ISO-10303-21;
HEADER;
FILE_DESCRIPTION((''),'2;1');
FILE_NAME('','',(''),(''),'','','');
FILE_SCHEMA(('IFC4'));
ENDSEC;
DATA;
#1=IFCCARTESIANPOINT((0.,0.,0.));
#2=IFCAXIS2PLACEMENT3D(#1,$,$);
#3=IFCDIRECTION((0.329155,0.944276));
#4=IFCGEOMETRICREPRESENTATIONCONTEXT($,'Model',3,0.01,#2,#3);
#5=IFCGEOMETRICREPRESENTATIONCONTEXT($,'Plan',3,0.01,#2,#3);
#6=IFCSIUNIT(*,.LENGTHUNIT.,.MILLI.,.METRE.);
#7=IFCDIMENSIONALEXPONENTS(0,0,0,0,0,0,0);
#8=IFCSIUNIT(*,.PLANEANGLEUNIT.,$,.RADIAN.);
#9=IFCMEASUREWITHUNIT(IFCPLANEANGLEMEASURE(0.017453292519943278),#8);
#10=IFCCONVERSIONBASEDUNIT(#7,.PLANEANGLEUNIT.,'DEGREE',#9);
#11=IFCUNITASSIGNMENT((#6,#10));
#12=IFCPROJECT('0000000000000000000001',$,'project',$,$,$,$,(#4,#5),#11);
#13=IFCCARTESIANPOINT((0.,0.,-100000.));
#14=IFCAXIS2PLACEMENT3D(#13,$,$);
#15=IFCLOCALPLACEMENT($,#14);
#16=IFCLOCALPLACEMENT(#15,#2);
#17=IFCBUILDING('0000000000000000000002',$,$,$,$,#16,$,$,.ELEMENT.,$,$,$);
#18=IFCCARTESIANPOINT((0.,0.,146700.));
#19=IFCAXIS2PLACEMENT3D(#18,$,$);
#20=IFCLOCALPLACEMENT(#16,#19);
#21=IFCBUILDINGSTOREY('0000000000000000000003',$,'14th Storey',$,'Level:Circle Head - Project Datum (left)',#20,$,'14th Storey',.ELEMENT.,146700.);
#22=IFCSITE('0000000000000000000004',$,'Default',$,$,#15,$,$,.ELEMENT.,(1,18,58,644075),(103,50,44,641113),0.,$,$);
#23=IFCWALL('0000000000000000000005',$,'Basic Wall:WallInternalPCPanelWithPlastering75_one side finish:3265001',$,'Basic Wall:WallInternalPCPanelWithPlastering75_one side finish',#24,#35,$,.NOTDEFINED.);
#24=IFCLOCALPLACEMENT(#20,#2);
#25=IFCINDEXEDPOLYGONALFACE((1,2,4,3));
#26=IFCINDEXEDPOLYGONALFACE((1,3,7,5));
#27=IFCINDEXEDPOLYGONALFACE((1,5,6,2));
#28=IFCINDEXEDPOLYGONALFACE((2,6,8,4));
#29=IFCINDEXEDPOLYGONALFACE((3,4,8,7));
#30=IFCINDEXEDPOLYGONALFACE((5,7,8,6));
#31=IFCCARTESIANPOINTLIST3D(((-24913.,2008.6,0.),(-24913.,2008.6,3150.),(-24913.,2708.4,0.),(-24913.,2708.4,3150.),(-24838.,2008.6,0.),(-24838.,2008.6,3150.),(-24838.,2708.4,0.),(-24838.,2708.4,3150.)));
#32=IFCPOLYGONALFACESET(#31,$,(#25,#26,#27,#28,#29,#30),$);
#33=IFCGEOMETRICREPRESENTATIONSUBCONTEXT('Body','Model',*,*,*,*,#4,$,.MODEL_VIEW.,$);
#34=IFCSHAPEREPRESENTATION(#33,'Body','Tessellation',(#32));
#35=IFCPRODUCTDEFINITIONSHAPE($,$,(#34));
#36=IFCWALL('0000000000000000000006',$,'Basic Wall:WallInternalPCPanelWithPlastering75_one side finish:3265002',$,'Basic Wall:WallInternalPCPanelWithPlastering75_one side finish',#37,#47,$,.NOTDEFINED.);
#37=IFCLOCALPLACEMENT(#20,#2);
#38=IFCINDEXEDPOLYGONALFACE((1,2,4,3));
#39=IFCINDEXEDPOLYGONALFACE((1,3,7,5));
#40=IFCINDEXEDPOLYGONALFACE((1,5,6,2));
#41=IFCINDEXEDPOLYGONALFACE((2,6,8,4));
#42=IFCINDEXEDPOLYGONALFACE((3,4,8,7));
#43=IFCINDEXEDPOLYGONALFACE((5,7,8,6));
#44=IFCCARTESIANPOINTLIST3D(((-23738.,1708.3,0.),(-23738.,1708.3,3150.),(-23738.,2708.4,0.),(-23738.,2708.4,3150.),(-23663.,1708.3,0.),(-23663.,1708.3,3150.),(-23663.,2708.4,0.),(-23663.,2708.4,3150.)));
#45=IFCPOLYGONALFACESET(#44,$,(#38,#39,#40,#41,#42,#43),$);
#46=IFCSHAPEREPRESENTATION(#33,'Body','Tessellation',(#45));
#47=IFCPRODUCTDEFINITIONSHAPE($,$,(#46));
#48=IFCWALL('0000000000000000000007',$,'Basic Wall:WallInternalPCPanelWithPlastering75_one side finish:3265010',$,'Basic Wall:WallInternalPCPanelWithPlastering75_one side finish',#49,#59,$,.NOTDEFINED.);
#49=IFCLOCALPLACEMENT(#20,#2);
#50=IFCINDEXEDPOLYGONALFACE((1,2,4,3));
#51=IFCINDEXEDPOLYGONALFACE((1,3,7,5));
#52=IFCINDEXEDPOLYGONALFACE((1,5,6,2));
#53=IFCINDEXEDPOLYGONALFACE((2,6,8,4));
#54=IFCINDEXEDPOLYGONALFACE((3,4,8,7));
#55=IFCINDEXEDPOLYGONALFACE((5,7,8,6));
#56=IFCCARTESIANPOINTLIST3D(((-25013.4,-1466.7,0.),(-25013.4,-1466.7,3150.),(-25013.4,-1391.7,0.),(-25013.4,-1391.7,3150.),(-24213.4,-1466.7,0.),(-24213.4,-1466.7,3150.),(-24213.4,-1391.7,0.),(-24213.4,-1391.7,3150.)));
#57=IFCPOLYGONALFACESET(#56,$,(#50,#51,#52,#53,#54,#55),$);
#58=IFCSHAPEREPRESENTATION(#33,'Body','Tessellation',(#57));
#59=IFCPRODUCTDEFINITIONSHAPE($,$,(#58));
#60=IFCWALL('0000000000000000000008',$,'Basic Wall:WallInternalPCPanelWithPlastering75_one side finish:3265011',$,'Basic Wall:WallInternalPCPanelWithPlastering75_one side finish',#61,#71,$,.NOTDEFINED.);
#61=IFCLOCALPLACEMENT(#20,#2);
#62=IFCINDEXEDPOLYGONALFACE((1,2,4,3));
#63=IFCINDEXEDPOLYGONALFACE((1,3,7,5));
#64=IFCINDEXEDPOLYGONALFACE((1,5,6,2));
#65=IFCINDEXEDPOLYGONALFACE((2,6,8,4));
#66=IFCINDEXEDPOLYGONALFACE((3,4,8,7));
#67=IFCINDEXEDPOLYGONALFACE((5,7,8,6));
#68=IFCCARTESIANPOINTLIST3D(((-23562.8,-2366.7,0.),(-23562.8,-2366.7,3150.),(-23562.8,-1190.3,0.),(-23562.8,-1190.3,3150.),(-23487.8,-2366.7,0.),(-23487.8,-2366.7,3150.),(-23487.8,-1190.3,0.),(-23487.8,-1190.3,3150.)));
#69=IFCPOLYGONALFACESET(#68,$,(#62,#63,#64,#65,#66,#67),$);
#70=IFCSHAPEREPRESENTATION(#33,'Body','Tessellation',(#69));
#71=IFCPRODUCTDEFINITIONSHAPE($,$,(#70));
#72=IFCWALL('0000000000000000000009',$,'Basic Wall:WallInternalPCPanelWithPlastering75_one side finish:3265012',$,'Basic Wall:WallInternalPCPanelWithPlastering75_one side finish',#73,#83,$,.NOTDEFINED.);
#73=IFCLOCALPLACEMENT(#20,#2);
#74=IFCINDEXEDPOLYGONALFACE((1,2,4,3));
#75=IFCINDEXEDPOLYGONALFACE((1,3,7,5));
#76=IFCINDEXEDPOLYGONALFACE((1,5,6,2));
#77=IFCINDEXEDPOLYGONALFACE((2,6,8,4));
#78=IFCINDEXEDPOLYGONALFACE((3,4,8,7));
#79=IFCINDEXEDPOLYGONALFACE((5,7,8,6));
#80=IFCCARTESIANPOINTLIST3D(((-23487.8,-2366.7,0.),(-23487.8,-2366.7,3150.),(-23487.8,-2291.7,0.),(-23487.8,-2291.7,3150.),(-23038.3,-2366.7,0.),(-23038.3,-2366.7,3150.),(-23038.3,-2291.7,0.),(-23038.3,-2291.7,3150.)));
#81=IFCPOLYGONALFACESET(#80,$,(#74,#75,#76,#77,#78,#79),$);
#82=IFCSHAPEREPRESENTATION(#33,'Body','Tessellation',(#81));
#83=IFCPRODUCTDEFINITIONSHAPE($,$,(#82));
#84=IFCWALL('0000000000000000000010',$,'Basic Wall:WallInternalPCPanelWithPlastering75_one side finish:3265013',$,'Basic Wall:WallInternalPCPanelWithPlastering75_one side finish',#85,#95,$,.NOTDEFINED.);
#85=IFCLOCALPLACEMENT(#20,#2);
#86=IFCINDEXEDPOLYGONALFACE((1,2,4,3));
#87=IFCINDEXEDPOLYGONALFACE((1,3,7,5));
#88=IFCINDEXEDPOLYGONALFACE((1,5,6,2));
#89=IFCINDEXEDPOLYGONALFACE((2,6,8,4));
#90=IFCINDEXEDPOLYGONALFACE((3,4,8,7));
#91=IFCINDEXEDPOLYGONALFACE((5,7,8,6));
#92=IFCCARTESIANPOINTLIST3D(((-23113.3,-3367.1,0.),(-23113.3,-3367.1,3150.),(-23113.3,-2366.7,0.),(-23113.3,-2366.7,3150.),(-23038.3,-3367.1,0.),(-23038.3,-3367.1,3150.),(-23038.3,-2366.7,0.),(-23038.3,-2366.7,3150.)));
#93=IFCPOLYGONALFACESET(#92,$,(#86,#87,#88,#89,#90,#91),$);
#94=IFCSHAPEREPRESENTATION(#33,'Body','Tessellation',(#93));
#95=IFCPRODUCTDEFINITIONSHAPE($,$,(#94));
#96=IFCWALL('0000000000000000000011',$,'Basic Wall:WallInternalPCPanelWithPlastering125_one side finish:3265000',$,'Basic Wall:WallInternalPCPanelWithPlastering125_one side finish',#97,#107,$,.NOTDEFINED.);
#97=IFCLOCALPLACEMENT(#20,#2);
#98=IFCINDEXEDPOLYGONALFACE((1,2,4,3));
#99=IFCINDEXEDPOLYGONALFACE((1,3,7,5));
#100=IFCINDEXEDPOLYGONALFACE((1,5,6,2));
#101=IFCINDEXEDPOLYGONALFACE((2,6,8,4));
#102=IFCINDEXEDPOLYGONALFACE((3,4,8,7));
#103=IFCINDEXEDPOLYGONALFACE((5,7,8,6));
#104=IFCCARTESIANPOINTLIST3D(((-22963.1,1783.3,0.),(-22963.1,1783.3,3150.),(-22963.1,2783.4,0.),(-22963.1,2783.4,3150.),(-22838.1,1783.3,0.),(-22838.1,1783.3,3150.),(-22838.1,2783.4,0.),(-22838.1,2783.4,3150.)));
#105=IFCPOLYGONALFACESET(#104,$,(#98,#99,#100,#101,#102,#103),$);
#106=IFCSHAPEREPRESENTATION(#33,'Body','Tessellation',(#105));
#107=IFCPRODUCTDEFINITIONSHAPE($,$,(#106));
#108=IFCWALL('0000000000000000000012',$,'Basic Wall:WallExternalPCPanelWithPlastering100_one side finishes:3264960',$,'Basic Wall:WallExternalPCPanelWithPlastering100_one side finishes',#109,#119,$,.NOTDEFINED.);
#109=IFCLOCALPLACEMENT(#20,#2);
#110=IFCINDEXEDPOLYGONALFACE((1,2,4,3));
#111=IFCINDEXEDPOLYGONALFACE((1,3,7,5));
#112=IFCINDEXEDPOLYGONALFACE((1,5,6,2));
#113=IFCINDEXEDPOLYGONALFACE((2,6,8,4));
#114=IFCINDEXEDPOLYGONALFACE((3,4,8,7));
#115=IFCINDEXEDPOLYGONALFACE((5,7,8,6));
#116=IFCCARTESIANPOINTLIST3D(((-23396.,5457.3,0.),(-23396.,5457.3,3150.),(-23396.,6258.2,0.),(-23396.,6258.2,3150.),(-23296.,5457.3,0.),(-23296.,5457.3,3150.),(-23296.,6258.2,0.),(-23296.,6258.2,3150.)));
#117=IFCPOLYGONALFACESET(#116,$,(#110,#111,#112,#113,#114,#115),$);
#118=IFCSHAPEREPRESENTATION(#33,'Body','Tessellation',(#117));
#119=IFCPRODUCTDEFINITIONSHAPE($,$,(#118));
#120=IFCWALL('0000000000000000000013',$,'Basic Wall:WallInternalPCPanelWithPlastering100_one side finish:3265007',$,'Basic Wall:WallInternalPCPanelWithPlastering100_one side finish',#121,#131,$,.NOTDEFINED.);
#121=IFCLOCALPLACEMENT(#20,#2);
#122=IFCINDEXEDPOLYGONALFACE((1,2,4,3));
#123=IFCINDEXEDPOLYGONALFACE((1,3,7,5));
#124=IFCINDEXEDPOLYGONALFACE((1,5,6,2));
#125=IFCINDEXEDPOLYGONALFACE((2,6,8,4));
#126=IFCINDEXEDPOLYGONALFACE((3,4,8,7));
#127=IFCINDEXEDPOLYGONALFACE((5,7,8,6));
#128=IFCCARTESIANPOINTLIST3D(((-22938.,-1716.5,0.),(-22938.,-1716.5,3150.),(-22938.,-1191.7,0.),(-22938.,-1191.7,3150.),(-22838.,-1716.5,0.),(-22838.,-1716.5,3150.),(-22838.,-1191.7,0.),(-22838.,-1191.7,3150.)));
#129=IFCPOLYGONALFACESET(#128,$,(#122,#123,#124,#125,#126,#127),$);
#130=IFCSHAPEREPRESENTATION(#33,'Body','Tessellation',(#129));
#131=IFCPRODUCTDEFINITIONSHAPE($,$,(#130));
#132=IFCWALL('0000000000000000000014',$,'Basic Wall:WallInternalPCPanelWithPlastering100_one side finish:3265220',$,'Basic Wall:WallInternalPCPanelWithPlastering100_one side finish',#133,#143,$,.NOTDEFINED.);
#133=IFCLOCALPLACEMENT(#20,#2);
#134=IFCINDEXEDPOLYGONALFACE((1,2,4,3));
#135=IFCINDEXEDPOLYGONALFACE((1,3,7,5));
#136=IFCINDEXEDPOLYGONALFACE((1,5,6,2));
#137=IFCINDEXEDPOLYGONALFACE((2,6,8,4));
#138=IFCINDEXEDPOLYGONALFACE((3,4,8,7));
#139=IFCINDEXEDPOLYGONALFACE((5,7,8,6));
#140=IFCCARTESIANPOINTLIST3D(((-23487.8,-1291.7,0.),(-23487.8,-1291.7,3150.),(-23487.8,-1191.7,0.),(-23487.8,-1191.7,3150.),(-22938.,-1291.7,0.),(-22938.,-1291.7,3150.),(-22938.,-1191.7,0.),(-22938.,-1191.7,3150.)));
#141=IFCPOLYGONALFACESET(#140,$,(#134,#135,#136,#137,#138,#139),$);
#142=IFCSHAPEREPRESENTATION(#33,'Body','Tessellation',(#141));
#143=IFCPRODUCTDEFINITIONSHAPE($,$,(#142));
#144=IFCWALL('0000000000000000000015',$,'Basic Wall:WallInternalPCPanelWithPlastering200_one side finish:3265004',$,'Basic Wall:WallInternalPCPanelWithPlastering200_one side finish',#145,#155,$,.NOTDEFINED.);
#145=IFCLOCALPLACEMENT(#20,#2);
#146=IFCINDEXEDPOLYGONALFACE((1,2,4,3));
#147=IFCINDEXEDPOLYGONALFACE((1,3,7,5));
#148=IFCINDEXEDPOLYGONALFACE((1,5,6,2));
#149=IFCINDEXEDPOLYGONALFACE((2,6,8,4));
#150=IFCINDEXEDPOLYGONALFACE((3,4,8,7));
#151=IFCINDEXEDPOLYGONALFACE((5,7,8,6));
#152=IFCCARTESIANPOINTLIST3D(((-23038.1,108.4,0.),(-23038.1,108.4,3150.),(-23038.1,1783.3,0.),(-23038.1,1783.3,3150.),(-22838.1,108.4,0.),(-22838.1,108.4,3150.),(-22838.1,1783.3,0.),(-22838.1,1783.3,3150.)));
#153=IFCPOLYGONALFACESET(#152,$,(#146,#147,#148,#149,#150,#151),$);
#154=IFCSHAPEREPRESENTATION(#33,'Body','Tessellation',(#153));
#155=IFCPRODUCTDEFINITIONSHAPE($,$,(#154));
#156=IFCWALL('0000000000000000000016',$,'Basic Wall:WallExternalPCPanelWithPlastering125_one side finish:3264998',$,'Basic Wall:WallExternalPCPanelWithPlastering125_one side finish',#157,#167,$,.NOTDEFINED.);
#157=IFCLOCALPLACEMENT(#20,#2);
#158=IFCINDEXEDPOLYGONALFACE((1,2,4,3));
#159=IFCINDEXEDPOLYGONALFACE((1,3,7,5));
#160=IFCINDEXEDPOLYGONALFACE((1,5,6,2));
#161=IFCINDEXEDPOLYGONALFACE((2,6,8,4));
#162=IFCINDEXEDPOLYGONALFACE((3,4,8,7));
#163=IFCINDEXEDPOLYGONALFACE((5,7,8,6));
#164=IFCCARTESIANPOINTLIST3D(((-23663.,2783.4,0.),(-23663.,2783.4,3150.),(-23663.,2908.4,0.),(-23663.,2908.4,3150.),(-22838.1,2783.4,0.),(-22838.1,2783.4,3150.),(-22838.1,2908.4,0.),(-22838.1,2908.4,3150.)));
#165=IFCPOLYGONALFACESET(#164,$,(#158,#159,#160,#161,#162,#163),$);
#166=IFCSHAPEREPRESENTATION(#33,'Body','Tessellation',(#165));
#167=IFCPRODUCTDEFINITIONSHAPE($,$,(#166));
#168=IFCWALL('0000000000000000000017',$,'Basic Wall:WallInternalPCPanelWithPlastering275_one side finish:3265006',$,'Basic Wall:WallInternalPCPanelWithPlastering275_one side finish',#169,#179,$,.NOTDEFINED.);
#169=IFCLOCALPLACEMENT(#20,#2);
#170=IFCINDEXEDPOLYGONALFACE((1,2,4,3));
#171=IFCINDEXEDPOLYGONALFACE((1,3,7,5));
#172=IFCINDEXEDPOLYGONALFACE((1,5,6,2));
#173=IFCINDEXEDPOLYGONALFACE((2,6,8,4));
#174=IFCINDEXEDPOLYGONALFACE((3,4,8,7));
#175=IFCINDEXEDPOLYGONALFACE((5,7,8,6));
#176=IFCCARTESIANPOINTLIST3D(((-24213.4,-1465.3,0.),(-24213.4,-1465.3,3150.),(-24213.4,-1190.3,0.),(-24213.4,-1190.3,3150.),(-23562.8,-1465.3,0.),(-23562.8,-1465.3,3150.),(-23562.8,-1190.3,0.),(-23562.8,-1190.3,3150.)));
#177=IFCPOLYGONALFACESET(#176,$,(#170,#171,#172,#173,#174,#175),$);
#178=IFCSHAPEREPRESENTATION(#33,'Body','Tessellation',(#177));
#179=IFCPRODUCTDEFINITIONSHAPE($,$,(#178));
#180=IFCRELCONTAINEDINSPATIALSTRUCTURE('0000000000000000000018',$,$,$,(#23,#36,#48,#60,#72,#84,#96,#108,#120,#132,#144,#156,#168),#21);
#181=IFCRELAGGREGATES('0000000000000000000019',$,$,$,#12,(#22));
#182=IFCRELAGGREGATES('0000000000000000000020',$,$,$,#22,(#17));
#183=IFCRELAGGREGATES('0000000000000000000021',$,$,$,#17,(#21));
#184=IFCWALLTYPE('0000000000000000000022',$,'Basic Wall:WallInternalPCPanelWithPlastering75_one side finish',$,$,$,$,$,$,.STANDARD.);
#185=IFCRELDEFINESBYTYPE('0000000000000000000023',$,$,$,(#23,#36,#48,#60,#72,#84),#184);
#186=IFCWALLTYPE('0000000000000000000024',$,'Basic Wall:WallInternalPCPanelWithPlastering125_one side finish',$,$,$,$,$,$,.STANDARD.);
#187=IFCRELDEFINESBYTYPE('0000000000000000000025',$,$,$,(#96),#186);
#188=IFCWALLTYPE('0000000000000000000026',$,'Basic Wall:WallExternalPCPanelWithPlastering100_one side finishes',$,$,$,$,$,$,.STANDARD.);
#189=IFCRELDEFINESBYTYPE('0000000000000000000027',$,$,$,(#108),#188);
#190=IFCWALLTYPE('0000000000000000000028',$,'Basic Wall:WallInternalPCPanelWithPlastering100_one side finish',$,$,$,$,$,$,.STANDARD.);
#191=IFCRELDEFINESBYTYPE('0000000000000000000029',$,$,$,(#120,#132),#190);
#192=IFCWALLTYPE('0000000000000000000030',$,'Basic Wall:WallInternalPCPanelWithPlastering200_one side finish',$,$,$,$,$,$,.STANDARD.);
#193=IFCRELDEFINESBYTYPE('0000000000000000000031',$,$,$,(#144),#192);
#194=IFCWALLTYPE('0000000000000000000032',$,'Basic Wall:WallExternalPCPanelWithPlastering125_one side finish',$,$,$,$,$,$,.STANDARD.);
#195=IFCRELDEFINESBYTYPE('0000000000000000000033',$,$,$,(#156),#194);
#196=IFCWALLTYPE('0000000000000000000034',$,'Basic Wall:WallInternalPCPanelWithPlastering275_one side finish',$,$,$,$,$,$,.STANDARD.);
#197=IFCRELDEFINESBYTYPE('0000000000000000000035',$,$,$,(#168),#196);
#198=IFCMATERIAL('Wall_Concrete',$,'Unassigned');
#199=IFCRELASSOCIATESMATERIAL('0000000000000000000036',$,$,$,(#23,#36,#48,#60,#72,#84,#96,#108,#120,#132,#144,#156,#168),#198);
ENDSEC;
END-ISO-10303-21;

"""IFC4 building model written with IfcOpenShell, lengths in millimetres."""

from ifc_helpers import new_model, entity, si_unit, converted_unit, direction, frame, origin, place, context, subcontext, project, spatial, indexed_curve, outline, extrude, material, type_object, element, save


model = new_model("IFC4")

# Units and contexts
model_context = context("Model", 3, precision=0.01, world=origin(), true_north=direction((0.329155, 0.944276)))
plan_context = context("Plan", 3, precision=0.01, world=origin(), true_north=direction((0.329155, 0.944276)))
body_context = subcontext(model_context, "Body", "Model", "MODEL_VIEW")
ifc_project = project(units=[si_unit("LENGTHUNIT", "METRE", prefix="MILLI"), converted_unit("PLANEANGLEUNIT", "DEGREE", entity("IfcPlaneAngleMeasure", 0.017453292519943278), si_unit("PLANEANGLEUNIT", "RADIAN"), dimensions=[0, 0, 0, 0, 0, 0, 0])], contexts=[model_context, plan_context])

# Site, building, storey
site_placement = place(None, frame((0.0, 0.0, -100000.0)))
site = spatial("IfcSite", under=ifc_project, at=site_placement, Name="Default", CompositionType="ELEMENT", RefLatitude=(1, 18, 58, 644075), RefLongitude=(103, 50, 44, 641113), RefElevation=0.0)
building_placement = place(site_placement, origin())
building = spatial("IfcBuilding", under=site, at=building_placement, CompositionType="ELEMENT")
storey_placement = place(building_placement, frame((0.0, 0.0, 146700.0)))
storey = spatial("IfcBuildingStorey", under=building, at=storey_placement, Name="14th Storey", ObjectType="Level:Circle Head - Project Datum (left)", LongName="14th Storey", CompositionType="ELEMENT", Elevation=146700.0)

# Walls
ifc_material_1 = material(Name="Wall_Concrete", Category="Unassigned")
wall_type_1 = type_object("IfcWallType", Name="Basic Wall:WallInternalPCPanelWithPlastering75_one side finish", PredefinedType="STANDARD")
wall_1_placement = place(storey_placement, frame((-24875.5, 2708.4, 0.0), z_axis=(0.0, 0.0, 1.0), x_axis=(0.0, -1.0, 0.0)))
element("IfcWall", 1, at=wall_1_placement, inside=storey, type_object=wall_type_1, material=ifc_material_1, Name="Basic Wall:WallInternalPCPanelWithPlastering75_one side finish:3265001", ObjectType="Basic Wall:WallInternalPCPanelWithPlastering75_one side finish", PredefinedType="NOTDEFINED", context=body_context, shape_type="SweptSolid", body=[
    extrude(outline(indexed_curve([(699.8, 37.5), (0.0, 37.5), (0.0, -37.5), (699.8, -37.5), (699.8, 37.5)], self_intersect=False)), origin(), (0.0, 0.0, 1.0), 3150.0),
])
wall_2_placement = place(storey_placement, frame((-23700.5, 1708.3, 0.0), z_axis=(0.0, 0.0, 1.0), x_axis=(0.0, 1.0, 0.0)))
element("IfcWall", 2, at=wall_2_placement, inside=storey, type_object=wall_type_1, material=ifc_material_1, Name="Basic Wall:WallInternalPCPanelWithPlastering75_one side finish:3265002", ObjectType="Basic Wall:WallInternalPCPanelWithPlastering75_one side finish", PredefinedType="NOTDEFINED", context=body_context, shape_type="SweptSolid", body=[
    extrude(outline(indexed_curve([(1000.1, 37.5), (0.0, 37.5), (0.0, -37.5), (1000.1, -37.5), (1000.1, 37.5)], self_intersect=False)), origin(), (0.0, 0.0, 1.0), 3150.0),
])
wall_3_placement = place(storey_placement, frame((-24213.4, -1429.2, 0.0), z_axis=(0.0, 0.0, 1.0), x_axis=(-1.0, 0.0, 0.0)))
element("IfcWall", 3, at=wall_3_placement, inside=storey, type_object=wall_type_1, material=ifc_material_1, Name="Basic Wall:WallInternalPCPanelWithPlastering75_one side finish:3265010", ObjectType="Basic Wall:WallInternalPCPanelWithPlastering75_one side finish", PredefinedType="NOTDEFINED", context=body_context, shape_type="SweptSolid", body=[
    extrude(outline(indexed_curve([(800.0, 37.5), (0.0, 37.5), (0.0, -37.5), (800.0, -37.5), (800.0, 37.5)], self_intersect=False)), origin(), (0.0, 0.0, 1.0), 3150.0),
])
wall_4_placement = place(storey_placement, frame((-23525.3, -2366.7, 0.0), z_axis=(0.0, 0.0, 1.0), x_axis=(0.0, 1.0, 0.0)))
element("IfcWall", 4, at=wall_4_placement, inside=storey, type_object=wall_type_1, material=ifc_material_1, Name="Basic Wall:WallInternalPCPanelWithPlastering75_one side finish:3265011", ObjectType="Basic Wall:WallInternalPCPanelWithPlastering75_one side finish", PredefinedType="NOTDEFINED", context=body_context, shape_type="SweptSolid", body=[
    extrude(outline(indexed_curve([(1176.4, 37.5), (0.0, 37.5), (0.0, -37.5), (1176.4, -37.5), (1176.4, 37.5)], self_intersect=False)), origin(), (0.0, 0.0, 1.0), 3150.0),
])
wall_5_placement = place(storey_placement, frame((-23038.3, -2329.2, 0.0), z_axis=(0.0, 0.0, 1.0), x_axis=(-1.0, 0.0, 0.0)))
element("IfcWall", 5, at=wall_5_placement, inside=storey, type_object=wall_type_1, material=ifc_material_1, Name="Basic Wall:WallInternalPCPanelWithPlastering75_one side finish:3265012", ObjectType="Basic Wall:WallInternalPCPanelWithPlastering75_one side finish", PredefinedType="NOTDEFINED", context=body_context, shape_type="SweptSolid", body=[
    extrude(outline(indexed_curve([(449.5, 37.5), (0.0, 37.5), (0.0, -37.5), (449.5, -37.5), (449.5, 37.5)], self_intersect=False)), origin(), (0.0, 0.0, 1.0), 3150.0),
])
wall_6_placement = place(storey_placement, frame((-23075.8, -3367.1, 0.0), z_axis=(0.0, 0.0, 1.0), x_axis=(0.0, 1.0, 0.0)))
element("IfcWall", 6, at=wall_6_placement, inside=storey, type_object=wall_type_1, material=ifc_material_1, Name="Basic Wall:WallInternalPCPanelWithPlastering75_one side finish:3265013", ObjectType="Basic Wall:WallInternalPCPanelWithPlastering75_one side finish", PredefinedType="NOTDEFINED", context=body_context, shape_type="SweptSolid", body=[
    extrude(outline(indexed_curve([(1000.4, 37.5), (0.0, 37.5), (0.0, -37.5), (1000.4, -37.5), (1000.4, 37.5)], self_intersect=False)), origin(), (0.0, 0.0, 1.0), 3150.0),
])
wall_type_2 = type_object("IfcWallType", Name="Basic Wall:WallInternalPCPanelWithPlastering125_one side finish", PredefinedType="STANDARD")
wall_7_placement = place(storey_placement, frame((-22900.6, 1783.3, 0.0), z_axis=(0.0, 0.0, 1.0), x_axis=(0.0, 1.0, 0.0)))
element("IfcWall", 7, at=wall_7_placement, inside=storey, type_object=wall_type_2, material=ifc_material_1, Name="Basic Wall:WallInternalPCPanelWithPlastering125_one side finish:3265000", ObjectType="Basic Wall:WallInternalPCPanelWithPlastering125_one side finish", PredefinedType="NOTDEFINED", context=body_context, shape_type="SweptSolid", body=[
    extrude(outline(indexed_curve([(1000.1, 62.5), (0.0, 62.5), (0.0, -62.5), (1000.1, -62.5), (1000.1, 62.5)], self_intersect=False)), origin(), (0.0, 0.0, 1.0), 3150.0),
])
wall_type_3 = type_object("IfcWallType", Name="Basic Wall:WallExternalPCPanelWithPlastering100_one side finishes", PredefinedType="STANDARD")
wall_8_placement = place(storey_placement, frame((-23346.0, 6258.2, 0.0), z_axis=(0.0, 0.0, 1.0), x_axis=(0.0, -1.0, 0.0)))
element("IfcWall", 8, at=wall_8_placement, inside=storey, type_object=wall_type_3, material=ifc_material_1, Name="Basic Wall:WallExternalPCPanelWithPlastering100_one side finishes:3264960", ObjectType="Basic Wall:WallExternalPCPanelWithPlastering100_one side finishes", PredefinedType="NOTDEFINED", context=body_context, shape_type="SweptSolid", body=[
    extrude(outline(indexed_curve([(801.0, 50.0), (0.0, 50.0), (0.0, -50.0), (801.0, -50.0), (801.0, 50.0)], self_intersect=False)), origin(), (0.0, 0.0, 1.0), 3150.0),
])
wall_type_4 = type_object("IfcWallType", Name="Basic Wall:WallInternalPCPanelWithPlastering100_one side finish", PredefinedType="STANDARD")
wall_9_placement = place(storey_placement, frame((-22888.0, -1716.5, 0.0), z_axis=(0.0, 0.0, 1.0), x_axis=(0.0, 1.0, 0.0)))
element("IfcWall", 9, at=wall_9_placement, inside=storey, type_object=wall_type_4, material=ifc_material_1, Name="Basic Wall:WallInternalPCPanelWithPlastering100_one side finish:3265007", ObjectType="Basic Wall:WallInternalPCPanelWithPlastering100_one side finish", PredefinedType="NOTDEFINED", context=body_context, shape_type="SweptSolid", body=[
    extrude(outline(indexed_curve([(524.8, 50.0), (0.0, 50.0), (0.0, -50.0), (524.8, -50.0), (524.8, 50.0)], self_intersect=False)), origin(), (0.0, 0.0, 1.0), 3150.0),
])
wall_10_placement = place(storey_placement, frame((-23487.8, -1241.7, 0.0)))
element("IfcWall", 10, at=wall_10_placement, inside=storey, type_object=wall_type_4, material=ifc_material_1, Name="Basic Wall:WallInternalPCPanelWithPlastering100_one side finish:3265220", ObjectType="Basic Wall:WallInternalPCPanelWithPlastering100_one side finish", PredefinedType="NOTDEFINED", context=body_context, shape_type="SweptSolid", body=[
    extrude(outline(indexed_curve([(549.9, 50.0), (0.0, 50.0), (0.0, -50.0), (549.9, -50.0), (549.9, 50.0)], self_intersect=False)), origin(), (0.0, 0.0, 1.0), 3150.0),
])
wall_type_5 = type_object("IfcWallType", Name="Basic Wall:WallInternalPCPanelWithPlastering200_one side finish", PredefinedType="STANDARD")
wall_11_placement = place(storey_placement, frame((-22938.1, 108.4, 0.0), z_axis=(0.0, 0.0, 1.0), x_axis=(0.0, 1.0, 0.0)))
element("IfcWall", 11, at=wall_11_placement, inside=storey, type_object=wall_type_5, material=ifc_material_1, Name="Basic Wall:WallInternalPCPanelWithPlastering200_one side finish:3265004", ObjectType="Basic Wall:WallInternalPCPanelWithPlastering200_one side finish", PredefinedType="NOTDEFINED", context=body_context, shape_type="SweptSolid", body=[
    extrude(outline(indexed_curve([(1674.9, 100.0), (0.0, 100.0), (0.0, -100.0), (1674.9, -100.0), (1674.9, 100.0)], self_intersect=False)), origin(), (0.0, 0.0, 1.0), 3150.0),
])
wall_type_6 = type_object("IfcWallType", Name="Basic Wall:WallExternalPCPanelWithPlastering125_one side finish", PredefinedType="STANDARD")
wall_12_placement = place(storey_placement, frame((-22838.1, 2845.9, 0.0), z_axis=(0.0, 0.0, 1.0), x_axis=(-1.0, 0.0, 0.0)))
element("IfcWall", 12, at=wall_12_placement, inside=storey, type_object=wall_type_6, material=ifc_material_1, Name="Basic Wall:WallExternalPCPanelWithPlastering125_one side finish:3264998", ObjectType="Basic Wall:WallExternalPCPanelWithPlastering125_one side finish", PredefinedType="NOTDEFINED", context=body_context, shape_type="SweptSolid", body=[
    extrude(outline(indexed_curve([(825.0, 62.5), (0.0, 62.5), (0.0, -62.5), (825.0, -62.5), (825.0, 62.5)], self_intersect=False)), origin(), (0.0, 0.0, 1.0), 3150.0),
])
wall_type_7 = type_object("IfcWallType", Name="Basic Wall:WallInternalPCPanelWithPlastering275_one side finish", PredefinedType="STANDARD")
wall_13_placement = place(storey_placement, frame((-23562.8, -1327.8, 0.0), z_axis=(0.0, 0.0, 1.0), x_axis=(-1.0, 0.0, 0.0)))
element("IfcWall", 13, at=wall_13_placement, inside=storey, type_object=wall_type_7, material=ifc_material_1, Name="Basic Wall:WallInternalPCPanelWithPlastering275_one side finish:3265006", ObjectType="Basic Wall:WallInternalPCPanelWithPlastering275_one side finish", PredefinedType="NOTDEFINED", context=body_context, shape_type="SweptSolid", body=[
    extrude(outline(indexed_curve([(650.6, 137.5), (0.0, 137.5), (0.0, -137.5), (650.6, -137.5), (650.6, 137.5)], self_intersect=False)), origin(), (0.0, 0.0, 1.0), 3150.0),
])

save(model, "model.ifc")
